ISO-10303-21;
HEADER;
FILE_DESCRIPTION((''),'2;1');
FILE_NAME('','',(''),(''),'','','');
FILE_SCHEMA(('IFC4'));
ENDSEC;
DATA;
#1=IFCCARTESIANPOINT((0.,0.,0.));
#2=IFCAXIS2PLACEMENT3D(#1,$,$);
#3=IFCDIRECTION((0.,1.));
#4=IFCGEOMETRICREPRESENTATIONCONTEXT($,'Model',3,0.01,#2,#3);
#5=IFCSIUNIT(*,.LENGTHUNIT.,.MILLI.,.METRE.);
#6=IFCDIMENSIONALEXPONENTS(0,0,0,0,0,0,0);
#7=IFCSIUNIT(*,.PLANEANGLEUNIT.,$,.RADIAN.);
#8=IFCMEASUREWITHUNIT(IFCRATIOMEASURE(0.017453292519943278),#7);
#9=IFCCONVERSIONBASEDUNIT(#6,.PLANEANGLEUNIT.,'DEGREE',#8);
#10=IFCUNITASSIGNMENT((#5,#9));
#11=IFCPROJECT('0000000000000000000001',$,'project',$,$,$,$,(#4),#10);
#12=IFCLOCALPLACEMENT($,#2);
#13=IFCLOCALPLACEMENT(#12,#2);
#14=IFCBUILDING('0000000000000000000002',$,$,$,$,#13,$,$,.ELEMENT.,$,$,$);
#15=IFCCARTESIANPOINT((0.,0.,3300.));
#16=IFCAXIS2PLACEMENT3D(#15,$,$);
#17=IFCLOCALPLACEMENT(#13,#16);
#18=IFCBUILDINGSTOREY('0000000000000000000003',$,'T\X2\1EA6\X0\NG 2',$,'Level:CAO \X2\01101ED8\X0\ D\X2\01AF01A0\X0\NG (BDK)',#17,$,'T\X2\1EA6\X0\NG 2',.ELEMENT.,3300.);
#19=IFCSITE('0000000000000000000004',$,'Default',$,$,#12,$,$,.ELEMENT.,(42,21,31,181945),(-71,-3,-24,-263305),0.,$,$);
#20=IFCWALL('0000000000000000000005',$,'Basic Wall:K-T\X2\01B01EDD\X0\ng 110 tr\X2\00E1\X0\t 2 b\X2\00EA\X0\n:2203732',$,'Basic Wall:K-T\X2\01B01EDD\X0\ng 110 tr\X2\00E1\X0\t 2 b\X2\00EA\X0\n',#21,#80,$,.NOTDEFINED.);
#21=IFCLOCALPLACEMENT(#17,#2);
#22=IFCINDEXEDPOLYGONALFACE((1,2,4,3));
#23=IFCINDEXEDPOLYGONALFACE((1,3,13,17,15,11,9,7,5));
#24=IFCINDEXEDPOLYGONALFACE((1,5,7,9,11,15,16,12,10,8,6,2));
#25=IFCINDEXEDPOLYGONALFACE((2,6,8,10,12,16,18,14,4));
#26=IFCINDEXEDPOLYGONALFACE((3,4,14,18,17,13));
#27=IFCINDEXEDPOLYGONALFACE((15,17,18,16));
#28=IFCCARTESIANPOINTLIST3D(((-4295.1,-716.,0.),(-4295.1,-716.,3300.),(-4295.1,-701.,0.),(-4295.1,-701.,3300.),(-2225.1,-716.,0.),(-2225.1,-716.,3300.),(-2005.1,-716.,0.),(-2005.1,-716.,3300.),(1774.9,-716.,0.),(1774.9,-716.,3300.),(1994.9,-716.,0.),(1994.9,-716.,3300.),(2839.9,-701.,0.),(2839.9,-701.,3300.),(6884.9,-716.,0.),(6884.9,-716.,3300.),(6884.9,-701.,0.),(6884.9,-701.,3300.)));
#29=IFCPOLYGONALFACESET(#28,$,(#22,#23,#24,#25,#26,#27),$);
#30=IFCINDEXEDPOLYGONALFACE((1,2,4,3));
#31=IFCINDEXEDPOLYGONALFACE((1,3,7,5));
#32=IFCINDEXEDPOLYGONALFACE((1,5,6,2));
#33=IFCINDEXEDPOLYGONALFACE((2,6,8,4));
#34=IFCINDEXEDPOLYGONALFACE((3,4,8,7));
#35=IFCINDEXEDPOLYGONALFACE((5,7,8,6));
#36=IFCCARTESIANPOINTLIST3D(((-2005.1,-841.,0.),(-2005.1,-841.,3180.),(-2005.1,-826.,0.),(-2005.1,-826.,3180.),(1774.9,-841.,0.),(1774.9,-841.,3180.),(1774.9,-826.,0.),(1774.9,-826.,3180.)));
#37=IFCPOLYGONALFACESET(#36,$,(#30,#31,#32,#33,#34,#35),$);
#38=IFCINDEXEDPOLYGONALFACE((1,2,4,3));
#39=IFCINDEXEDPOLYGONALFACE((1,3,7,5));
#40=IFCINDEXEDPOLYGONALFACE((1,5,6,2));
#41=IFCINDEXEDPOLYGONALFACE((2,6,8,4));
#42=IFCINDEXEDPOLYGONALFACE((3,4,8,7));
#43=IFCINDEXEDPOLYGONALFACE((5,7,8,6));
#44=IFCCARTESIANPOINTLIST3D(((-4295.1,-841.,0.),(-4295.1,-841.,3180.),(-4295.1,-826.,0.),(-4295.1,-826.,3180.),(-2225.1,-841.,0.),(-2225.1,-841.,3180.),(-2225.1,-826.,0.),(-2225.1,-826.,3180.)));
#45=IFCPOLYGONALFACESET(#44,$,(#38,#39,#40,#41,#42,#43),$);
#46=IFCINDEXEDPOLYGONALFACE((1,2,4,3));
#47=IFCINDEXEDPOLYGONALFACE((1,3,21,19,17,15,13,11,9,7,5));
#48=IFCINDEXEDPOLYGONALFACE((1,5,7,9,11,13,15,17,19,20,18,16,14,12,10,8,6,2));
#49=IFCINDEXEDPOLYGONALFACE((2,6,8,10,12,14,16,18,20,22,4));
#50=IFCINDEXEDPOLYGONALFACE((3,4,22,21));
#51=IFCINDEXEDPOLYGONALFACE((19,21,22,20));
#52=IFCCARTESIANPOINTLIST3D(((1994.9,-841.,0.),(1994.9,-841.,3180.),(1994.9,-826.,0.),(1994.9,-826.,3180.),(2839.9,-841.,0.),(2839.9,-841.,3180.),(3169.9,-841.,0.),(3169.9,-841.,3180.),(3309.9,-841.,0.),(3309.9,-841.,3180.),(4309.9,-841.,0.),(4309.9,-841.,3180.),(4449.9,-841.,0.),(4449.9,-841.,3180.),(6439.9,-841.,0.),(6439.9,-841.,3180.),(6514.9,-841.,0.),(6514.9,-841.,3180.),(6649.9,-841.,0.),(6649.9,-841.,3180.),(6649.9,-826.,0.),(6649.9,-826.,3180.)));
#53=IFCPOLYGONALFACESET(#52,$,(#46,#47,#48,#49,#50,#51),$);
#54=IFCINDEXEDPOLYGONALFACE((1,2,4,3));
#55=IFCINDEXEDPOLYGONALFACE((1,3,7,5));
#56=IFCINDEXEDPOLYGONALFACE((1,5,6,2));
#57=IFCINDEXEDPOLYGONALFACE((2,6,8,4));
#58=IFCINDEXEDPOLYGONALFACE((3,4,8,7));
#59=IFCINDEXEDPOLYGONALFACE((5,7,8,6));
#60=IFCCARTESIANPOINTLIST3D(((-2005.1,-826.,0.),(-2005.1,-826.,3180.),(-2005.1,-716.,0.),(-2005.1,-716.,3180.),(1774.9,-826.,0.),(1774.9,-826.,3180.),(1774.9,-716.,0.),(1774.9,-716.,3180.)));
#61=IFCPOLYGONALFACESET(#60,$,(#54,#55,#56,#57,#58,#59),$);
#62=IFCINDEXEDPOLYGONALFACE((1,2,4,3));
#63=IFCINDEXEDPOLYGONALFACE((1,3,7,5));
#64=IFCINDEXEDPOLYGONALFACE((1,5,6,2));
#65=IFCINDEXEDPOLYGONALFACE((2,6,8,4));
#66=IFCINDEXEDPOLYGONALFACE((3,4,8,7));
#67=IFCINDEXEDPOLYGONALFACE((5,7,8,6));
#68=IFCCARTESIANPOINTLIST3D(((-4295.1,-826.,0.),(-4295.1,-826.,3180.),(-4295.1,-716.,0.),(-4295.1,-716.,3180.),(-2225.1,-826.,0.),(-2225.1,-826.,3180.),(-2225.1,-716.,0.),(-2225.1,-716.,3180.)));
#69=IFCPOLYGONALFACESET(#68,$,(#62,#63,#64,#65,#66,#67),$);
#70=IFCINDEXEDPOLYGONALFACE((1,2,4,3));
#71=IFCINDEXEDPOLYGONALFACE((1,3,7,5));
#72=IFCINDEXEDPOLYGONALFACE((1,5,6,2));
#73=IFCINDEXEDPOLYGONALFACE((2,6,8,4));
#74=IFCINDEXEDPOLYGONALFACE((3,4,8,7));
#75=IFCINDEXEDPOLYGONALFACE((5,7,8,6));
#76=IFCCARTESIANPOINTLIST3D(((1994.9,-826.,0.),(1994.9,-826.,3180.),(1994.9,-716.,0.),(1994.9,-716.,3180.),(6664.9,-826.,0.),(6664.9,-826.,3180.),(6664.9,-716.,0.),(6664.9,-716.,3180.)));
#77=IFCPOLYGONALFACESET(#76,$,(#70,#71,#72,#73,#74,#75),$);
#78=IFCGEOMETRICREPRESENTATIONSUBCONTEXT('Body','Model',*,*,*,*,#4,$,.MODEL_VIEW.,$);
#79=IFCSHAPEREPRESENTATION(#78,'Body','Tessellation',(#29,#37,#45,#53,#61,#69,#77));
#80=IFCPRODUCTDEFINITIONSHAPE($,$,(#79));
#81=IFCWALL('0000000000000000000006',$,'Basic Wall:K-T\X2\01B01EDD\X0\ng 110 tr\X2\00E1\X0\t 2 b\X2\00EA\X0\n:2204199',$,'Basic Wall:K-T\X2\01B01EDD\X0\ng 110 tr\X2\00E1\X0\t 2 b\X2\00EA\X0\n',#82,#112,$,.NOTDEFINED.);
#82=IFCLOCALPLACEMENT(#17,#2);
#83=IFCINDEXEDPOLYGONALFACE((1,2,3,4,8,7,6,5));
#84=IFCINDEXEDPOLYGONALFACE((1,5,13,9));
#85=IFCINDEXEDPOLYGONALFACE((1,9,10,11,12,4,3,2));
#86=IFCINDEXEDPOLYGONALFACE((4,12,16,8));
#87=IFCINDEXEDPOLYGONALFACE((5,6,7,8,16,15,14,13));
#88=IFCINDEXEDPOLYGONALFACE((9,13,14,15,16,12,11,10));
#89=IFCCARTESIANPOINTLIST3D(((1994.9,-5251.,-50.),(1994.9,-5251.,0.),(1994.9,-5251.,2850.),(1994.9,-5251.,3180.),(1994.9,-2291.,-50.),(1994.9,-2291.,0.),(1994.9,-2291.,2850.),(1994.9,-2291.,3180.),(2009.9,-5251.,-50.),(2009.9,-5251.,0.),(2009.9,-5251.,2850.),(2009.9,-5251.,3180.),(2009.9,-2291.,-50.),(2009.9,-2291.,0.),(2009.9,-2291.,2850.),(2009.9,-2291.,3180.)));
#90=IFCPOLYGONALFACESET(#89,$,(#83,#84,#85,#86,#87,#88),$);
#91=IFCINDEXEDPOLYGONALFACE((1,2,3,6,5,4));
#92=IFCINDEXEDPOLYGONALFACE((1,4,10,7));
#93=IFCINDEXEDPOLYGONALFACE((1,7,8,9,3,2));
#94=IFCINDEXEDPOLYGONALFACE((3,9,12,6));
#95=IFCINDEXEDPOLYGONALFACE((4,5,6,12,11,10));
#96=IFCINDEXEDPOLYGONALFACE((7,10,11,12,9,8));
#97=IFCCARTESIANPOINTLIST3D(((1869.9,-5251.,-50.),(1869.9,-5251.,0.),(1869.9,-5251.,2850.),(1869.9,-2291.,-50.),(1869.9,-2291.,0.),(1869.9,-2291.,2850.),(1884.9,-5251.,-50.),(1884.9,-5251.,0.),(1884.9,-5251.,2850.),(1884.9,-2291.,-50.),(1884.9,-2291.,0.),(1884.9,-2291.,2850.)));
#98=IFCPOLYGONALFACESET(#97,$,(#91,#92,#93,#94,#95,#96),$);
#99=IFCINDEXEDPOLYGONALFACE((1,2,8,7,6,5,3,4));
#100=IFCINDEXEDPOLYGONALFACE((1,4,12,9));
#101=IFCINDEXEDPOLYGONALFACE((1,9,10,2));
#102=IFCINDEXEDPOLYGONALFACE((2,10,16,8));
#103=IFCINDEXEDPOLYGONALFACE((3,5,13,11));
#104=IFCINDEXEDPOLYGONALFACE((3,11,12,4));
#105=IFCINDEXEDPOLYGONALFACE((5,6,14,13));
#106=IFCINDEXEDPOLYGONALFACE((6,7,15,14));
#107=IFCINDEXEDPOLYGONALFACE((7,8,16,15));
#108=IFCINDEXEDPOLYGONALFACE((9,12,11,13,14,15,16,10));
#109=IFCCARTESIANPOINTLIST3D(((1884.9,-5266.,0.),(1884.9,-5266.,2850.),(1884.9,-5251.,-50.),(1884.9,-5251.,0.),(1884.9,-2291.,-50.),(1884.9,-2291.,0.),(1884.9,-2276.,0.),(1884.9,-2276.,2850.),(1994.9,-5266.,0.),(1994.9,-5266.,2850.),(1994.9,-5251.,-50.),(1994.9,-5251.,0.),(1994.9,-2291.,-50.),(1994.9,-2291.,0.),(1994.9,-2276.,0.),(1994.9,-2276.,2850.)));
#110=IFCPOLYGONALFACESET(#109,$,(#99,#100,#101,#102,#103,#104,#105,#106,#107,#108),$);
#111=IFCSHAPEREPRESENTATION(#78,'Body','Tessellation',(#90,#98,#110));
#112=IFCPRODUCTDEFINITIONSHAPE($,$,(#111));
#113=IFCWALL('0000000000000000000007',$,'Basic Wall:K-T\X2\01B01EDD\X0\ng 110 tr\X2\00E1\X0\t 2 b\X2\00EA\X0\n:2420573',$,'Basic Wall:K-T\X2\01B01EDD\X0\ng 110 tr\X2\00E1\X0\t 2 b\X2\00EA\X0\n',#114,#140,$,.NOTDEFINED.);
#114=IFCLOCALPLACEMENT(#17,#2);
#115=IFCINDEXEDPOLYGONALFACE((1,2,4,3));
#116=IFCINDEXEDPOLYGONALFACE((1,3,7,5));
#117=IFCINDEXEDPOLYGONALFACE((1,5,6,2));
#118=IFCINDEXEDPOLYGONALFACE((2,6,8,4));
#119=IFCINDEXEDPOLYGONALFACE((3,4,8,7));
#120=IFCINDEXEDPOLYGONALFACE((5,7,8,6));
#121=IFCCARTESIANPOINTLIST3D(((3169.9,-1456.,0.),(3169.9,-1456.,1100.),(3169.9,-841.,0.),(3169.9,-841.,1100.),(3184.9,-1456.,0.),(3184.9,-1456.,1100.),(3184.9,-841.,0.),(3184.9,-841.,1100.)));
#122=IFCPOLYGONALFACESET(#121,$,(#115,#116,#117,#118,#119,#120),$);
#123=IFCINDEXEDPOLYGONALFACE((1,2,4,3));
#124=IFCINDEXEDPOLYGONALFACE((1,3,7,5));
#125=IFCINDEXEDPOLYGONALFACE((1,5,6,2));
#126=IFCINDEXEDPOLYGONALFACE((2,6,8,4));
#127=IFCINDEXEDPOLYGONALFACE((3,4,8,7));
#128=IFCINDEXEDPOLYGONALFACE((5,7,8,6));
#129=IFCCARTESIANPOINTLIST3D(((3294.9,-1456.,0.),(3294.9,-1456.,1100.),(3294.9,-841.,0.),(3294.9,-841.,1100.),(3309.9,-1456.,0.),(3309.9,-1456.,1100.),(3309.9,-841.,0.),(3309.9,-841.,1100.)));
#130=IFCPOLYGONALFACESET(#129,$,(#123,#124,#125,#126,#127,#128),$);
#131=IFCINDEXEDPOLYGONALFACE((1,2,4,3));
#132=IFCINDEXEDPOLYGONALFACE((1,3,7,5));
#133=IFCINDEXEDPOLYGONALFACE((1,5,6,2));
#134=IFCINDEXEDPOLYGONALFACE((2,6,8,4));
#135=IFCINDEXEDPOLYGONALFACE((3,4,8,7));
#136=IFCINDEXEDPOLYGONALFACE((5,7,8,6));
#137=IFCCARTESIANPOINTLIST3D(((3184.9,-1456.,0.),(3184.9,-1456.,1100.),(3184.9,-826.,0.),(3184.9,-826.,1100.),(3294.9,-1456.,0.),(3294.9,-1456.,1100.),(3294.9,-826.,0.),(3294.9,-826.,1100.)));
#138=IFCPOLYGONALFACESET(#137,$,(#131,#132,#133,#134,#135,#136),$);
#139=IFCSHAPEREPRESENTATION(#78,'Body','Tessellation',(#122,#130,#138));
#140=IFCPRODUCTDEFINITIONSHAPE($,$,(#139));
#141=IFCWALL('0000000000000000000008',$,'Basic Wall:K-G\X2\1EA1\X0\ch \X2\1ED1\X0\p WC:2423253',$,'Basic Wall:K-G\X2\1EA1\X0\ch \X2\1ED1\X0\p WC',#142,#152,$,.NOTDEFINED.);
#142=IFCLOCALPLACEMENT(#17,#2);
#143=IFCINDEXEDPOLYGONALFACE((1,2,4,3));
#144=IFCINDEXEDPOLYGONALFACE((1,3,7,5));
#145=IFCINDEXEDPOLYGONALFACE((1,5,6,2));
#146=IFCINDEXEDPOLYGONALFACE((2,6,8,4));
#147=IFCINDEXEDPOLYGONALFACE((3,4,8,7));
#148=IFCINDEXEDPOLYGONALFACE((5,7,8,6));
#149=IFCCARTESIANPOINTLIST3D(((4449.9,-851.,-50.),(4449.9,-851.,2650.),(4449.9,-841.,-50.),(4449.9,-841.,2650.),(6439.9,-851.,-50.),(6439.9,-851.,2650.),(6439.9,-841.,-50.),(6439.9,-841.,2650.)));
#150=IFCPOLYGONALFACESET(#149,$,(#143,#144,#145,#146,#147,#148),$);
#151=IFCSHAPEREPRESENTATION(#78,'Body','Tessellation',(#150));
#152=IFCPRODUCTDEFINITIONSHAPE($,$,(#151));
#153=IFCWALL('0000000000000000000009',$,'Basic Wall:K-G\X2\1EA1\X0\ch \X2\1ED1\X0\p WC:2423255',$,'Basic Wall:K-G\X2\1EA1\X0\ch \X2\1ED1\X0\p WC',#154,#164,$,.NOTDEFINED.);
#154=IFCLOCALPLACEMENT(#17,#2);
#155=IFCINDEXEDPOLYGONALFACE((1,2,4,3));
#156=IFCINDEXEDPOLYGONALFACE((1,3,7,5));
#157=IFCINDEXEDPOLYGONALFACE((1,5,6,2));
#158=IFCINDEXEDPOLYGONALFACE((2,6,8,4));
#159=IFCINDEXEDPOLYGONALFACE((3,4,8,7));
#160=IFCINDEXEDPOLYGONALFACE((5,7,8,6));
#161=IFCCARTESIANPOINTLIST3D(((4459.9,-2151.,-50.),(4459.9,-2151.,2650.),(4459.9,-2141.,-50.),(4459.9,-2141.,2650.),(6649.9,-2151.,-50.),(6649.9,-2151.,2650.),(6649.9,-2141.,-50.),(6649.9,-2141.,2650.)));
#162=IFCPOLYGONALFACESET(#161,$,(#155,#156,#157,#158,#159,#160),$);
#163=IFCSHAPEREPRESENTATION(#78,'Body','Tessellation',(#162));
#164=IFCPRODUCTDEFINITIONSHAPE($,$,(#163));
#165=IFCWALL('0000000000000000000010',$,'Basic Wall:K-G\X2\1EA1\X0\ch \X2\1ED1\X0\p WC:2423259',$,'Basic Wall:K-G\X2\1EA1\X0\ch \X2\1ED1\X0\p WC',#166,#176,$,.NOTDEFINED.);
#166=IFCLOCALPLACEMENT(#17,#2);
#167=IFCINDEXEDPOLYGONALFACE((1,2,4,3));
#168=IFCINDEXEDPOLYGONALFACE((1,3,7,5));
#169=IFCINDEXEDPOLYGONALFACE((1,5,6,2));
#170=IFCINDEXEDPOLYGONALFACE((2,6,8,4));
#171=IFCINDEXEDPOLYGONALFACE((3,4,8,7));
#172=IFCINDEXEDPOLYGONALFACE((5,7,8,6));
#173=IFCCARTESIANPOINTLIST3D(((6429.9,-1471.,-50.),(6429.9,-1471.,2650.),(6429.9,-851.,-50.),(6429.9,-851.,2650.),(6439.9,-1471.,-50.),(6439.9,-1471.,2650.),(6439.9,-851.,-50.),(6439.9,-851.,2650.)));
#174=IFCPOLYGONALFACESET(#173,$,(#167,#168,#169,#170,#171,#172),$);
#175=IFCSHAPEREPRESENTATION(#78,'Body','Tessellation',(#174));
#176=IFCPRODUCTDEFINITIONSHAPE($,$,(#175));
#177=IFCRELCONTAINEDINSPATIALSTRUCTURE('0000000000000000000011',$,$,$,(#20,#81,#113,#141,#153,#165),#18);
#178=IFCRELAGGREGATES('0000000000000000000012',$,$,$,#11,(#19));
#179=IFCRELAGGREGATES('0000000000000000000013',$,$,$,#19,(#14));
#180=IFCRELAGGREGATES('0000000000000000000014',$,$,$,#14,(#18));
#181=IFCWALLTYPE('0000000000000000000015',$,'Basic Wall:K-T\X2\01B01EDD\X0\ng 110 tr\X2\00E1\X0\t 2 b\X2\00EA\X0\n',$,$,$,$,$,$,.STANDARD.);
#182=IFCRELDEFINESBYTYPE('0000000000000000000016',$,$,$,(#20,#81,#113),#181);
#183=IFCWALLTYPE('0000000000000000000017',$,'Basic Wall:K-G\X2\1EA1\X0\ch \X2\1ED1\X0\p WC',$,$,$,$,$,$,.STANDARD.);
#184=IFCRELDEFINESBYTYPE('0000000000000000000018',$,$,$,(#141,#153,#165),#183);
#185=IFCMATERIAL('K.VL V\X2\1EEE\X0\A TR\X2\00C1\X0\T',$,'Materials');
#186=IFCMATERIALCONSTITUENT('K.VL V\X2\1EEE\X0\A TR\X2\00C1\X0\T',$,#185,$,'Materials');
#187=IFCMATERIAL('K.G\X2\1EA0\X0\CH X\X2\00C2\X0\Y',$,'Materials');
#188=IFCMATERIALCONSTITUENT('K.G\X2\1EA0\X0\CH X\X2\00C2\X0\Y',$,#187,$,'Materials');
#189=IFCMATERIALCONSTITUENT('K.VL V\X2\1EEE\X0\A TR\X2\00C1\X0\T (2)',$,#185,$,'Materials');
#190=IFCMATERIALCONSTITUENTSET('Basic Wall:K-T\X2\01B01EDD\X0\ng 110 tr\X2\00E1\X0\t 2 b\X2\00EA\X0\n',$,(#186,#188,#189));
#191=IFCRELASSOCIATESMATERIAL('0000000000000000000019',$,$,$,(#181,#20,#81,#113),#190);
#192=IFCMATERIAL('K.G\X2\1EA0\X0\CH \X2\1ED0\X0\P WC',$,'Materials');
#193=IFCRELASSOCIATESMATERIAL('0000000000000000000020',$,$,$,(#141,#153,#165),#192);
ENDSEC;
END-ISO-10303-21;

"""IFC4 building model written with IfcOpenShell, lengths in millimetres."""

from ifc_helpers import new_model, entity, si_unit, converted_unit, direction, frame, origin, place, context, subcontext, project, spatial, indexed_curve, outline, extrude, material, constituent, constituent_set, type_object, element, save


model = new_model("IFC4")

# Units and contexts
model_context = context("Model", 3, precision=0.01, world=origin(), true_north=direction((0.0, 1.0)))
body_context = subcontext(model_context, "Body", "Model", "MODEL_VIEW")
ifc_project = project(units=[si_unit("LENGTHUNIT", "METRE", prefix="MILLI"), converted_unit("PLANEANGLEUNIT", "DEGREE", entity("IfcRatioMeasure", 0.017453292519943278), si_unit("PLANEANGLEUNIT", "RADIAN"), dimensions=[0, 0, 0, 0, 0, 0, 0])], contexts=[model_context])

# Site, building, storey
site_placement = place(None, origin())
site = spatial("IfcSite", under=ifc_project, at=site_placement, Name="Default", CompositionType="ELEMENT", RefLatitude=(42, 21, 31, 181945), RefLongitude=(-71, -3, -24, -263305), RefElevation=0.0)
building_placement = place(site_placement, origin())
building = spatial("IfcBuilding", under=site, at=building_placement, CompositionType="ELEMENT")
storey_placement = place(building_placement, frame((0.0, 0.0, 3300.0)))
storey = spatial("IfcBuildingStorey", under=building, at=storey_placement, Name="TẦNG 2", ObjectType="Level:CAO ĐỘ DƯƠNG (BDK)", LongName="TẦNG 2", CompositionType="ELEMENT", Elevation=3300.0)

# Shared definitions
ifc_material_1 = material(Name="K.VL VỮA TRÁT", Category="Materials")
ifc_material_2 = material(Name="K.GẠCH XÂY", Category="Materials")

# Wall
ifc_constituent_1 = constituent(ifc_material_1, Name="K.VL VỮA TRÁT", Category="Materials")
ifc_constituent_2 = constituent(ifc_material_2, Name="K.GẠCH XÂY", Category="Materials")
ifc_constituent_3 = constituent(ifc_material_1, Name="K.VL VỮA TRÁT (2)", Category="Materials")
ifc_constituent_set_1 = constituent_set(constituents=[ifc_constituent_1, ifc_constituent_2, ifc_constituent_3], Name="Basic Wall:K-Tường 110 trát 2 bên")
wall_type_1 = type_object("IfcWallType", Name="Basic Wall:K-Tường 110 trát 2 bên", PredefinedType="STANDARD", material=ifc_constituent_set_1)
wall_1_placement = place(storey_placement, frame((6649.9, -771.0, 0.0), z_axis=(0.0, 0.0, 1.0), x_axis=(-1.0, 0.0, 0.0)))
element("IfcWall", 1, at=wall_1_placement, inside=storey, type_object=wall_type_1, material=ifc_constituent_set_1, Name="Basic Wall:K-Tường 110 trát 2 bên:2203732", ObjectType="Basic Wall:K-Tường 110 trát 2 bên", PredefinedType="NOTDEFINED", context=body_context, shape_type="SweptSolid", body=[
    extrude(outline(indexed_curve([(-2000.0, -10.0), (5135.0, -10.0), (5135.0, 5.0), (3065.0, 5.0), (2845.0, 5.0), (-935.0, 5.0), (-1155.0, 5.0), (-6045.0, 5.0), (-6045.0, -10.0), (-2000.0, -10.0)], self_intersect=False)), frame((5810.0, -60.0, 0.0)), (0.0, 0.0, 1.0), 3300.0),
    extrude(outline(indexed_curve([(-7.5, -1890.0), (7.5, -1890.0), (7.5, 1890.0), (-7.5, 1890.0), (-7.5, -1890.0)], self_intersect=False)), frame((6765.0, 62.5, 0.0), z_axis=(0.0, 0.0, 1.0), x_axis=(0.0, -1.0, 0.0)), (0.0, 0.0, 1.0), 3180.0),
    extrude(outline(indexed_curve([(-7.5, -1035.0), (7.5, -1035.0), (7.5, 1035.0), (-7.5, 1035.0), (-7.5, -1035.0)], self_intersect=False)), frame((9910.0, 62.5, 0.0), z_axis=(0.0, 0.0, 1.0), x_axis=(0.0, -1.0, 0.0)), (0.0, 0.0, 1.0), 3180.0),
    extrude(outline(indexed_curve([(-1553.2, -2.7), (-1223.2, -2.7), (-1083.2, -2.7), (-83.2, -2.7), (56.8, -2.7), (2046.8, -2.7), (2121.8, -2.7), (2256.8, -2.7), (2256.8, 12.3), (-2398.2, 12.3), (-2398.2, -2.7), (-1553.2, -2.7)], self_intersect=False)), frame((2256.8, 67.3, 0.0), z_axis=(0.0, 0.0, 1.0), x_axis=(-1.0, 0.0, 0.0)), (0.0, 0.0, 1.0), 3180.0),
    extrude(outline(indexed_curve([(-1890.0, -55.0), (1890.0, -55.0), (1890.0, 55.0), (-1890.0, 55.0), (-1890.0, -55.0)], self_intersect=False)), frame((6765.0, 0.0, 0.0)), (0.0, 0.0, 1.0), 3180.0),
    extrude(outline(indexed_curve([(-1035.0, -55.0), (1035.0, -55.0), (1035.0, 55.0), (-1035.0, 55.0), (-1035.0, -55.0)], self_intersect=False)), frame((9910.0, 0.0, 0.0)), (0.0, 0.0, 1.0), 3180.0),
    extrude(outline(indexed_curve([(-2335.0, -55.0), (2335.0, -55.0), (2335.0, 55.0), (-2335.0, 55.0), (-2335.0, -55.0)], self_intersect=False)), frame((2320.0, 0.0, 0.0)), (0.0, 0.0, 1.0), 3180.0),
])

# Wall
wall_2_placement = place(storey_placement, frame((1939.9, -5251.0, -50.0), z_axis=(0.0, 0.0, 1.0), x_axis=(0.0, 1.0, 0.0)))
element("IfcWall", 2, at=wall_2_placement, inside=storey, type_object=wall_type_1, material=ifc_constituent_set_1, Name="Basic Wall:K-Tường 110 trát 2 bên:2204199", ObjectType="Basic Wall:K-Tường 110 trát 2 bên", PredefinedType="NOTDEFINED", context=body_context, shape_type="SweptSolid", body=[
    extrude(outline(indexed_curve([(-1545.0, -1480.0), (-1495.0, -1480.0), (1355.0, -1480.0), (1685.0, -1480.0), (1685.0, 1480.0), (1355.0, 1480.0), (-1495.0, 1480.0), (-1545.0, 1480.0), (-1545.0, -1480.0)], self_intersect=False)), frame((1480.0, -55.0, 1545.0), z_axis=(0.0, -1.0, 0.0), x_axis=(0.0, 0.0, 1.0)), (0.0, 0.0, 1.0), 15.0),
    extrude(outline(indexed_curve([(-983.3, -1480.0), (-933.3, -1480.0), (1916.7, -1480.0), (1916.7, 1480.0), (-933.3, 1480.0), (-983.3, 1480.0), (-983.3, -1480.0)], self_intersect=False)), frame((1480.0, 70.0, 983.3), z_axis=(0.0, -1.0, 0.0), x_axis=(0.0, 0.0, 1.0)), (0.0, 0.0, 1.0), 15.0),
    extrude(outline(indexed_curve([(-750.0, 1480.0), (-750.0, -1480.0), (-700.0, -1480.0), (-700.0, -1495.0), (2150.0, -1495.0), (2150.0, 1495.0), (-700.0, 1495.0), (-700.0, 1480.0), (-750.0, 1480.0)], self_intersect=False)), frame((1480.0, 55.0, 750.0), z_axis=(0.0, 1.0, 0.0), x_axis=(0.0, 0.0, 1.0)), (0.0, 0.0, -1.0), 110.0),
])

# Walls
wall_3_placement = place(storey_placement, frame((3239.9, -841.0, 0.0), z_axis=(0.0, 0.0, 1.0), x_axis=(0.0, -1.0, 0.0)))
element("IfcWall", 3, at=wall_3_placement, inside=storey, type_object=wall_type_1, material=ifc_constituent_set_1, Name="Basic Wall:K-Tường 110 trát 2 bên:2420573", ObjectType="Basic Wall:K-Tường 110 trát 2 bên", PredefinedType="NOTDEFINED", context=body_context, shape_type="SweptSolid", body=[
    extrude(outline(indexed_curve([(-7.5, -307.5), (7.5, -307.5), (7.5, 307.5), (-7.5, 307.5), (-7.5, -307.5)], self_intersect=False)), frame((307.5, -62.5, 0.0), z_axis=(0.0, 0.0, 1.0), x_axis=(0.0, 1.0, 0.0)), (0.0, 0.0, 1.0), 1100.0),
    extrude(outline(indexed_curve([(-7.5, -307.5), (7.5, -307.5), (7.5, 307.5), (-7.5, 307.5), (-7.5, -307.5)], self_intersect=False)), frame((307.5, 62.5, 0.0), z_axis=(0.0, 0.0, 1.0), x_axis=(0.0, -1.0, 0.0)), (0.0, 0.0, 1.0), 1100.0),
    extrude(outline(indexed_curve([(-315.0, -55.0), (315.0, -55.0), (315.0, 55.0), (-315.0, 55.0), (-315.0, -55.0)], self_intersect=False)), frame((300.0, 0.0, 0.0)), (0.0, 0.0, 1.0), 1100.0),
])
ifc_material_3 = material(Name="K.GẠCH ỐP WC", Category="Materials")
wall_type_2 = type_object("IfcWallType", Name="Basic Wall:K-Gạch ốp WC", PredefinedType="STANDARD")
wall_4_placement = place(storey_placement, frame((4449.9, -846.0, -50.0)))
element("IfcWall", 4, at=wall_4_placement, inside=storey, type_object=wall_type_2, material=ifc_material_3, Name="Basic Wall:K-Gạch ốp WC:2423253", ObjectType="Basic Wall:K-Gạch ốp WC", PredefinedType="NOTDEFINED", context=body_context, shape_type="SweptSolid", body=[
    extrude(outline(indexed_curve([(1990.0, 5.0), (0.0, 5.0), (0.0, -5.0), (1990.0, -5.0), (1990.0, 5.0)], self_intersect=False)), origin(), (0.0, 0.0, 1.0), 2700.0),
])
wall_5_placement = place(storey_placement, frame((6649.9, -2146.0, -50.0), z_axis=(0.0, 0.0, 1.0), x_axis=(-1.0, 0.0, 0.0)))
element("IfcWall", 5, at=wall_5_placement, inside=storey, type_object=wall_type_2, material=ifc_material_3, Name="Basic Wall:K-Gạch ốp WC:2423255", ObjectType="Basic Wall:K-Gạch ốp WC", PredefinedType="NOTDEFINED", context=body_context, shape_type="SweptSolid", body=[
    extrude(outline(indexed_curve([(2190.0, 5.0), (0.0, 5.0), (0.0, -5.0), (2190.0, -5.0), (2190.0, 5.0)], self_intersect=False)), origin(), (0.0, 0.0, 1.0), 2700.0),
])
wall_6_placement = place(storey_placement, frame((6434.9, -851.0, -50.0), z_axis=(0.0, 0.0, 1.0), x_axis=(0.0, -1.0, 0.0)))
element("IfcWall", 6, at=wall_6_placement, inside=storey, type_object=wall_type_2, material=ifc_material_3, Name="Basic Wall:K-Gạch ốp WC:2423259", ObjectType="Basic Wall:K-Gạch ốp WC", PredefinedType="NOTDEFINED", context=body_context, shape_type="SweptSolid", body=[
    extrude(outline(indexed_curve([(620.0, 5.0), (0.0, 5.0), (0.0, -5.0), (620.0, -5.0), (620.0, 5.0)], self_intersect=False)), origin(), (0.0, 0.0, 1.0), 2700.0),
])

save(model, "model.ifc")
